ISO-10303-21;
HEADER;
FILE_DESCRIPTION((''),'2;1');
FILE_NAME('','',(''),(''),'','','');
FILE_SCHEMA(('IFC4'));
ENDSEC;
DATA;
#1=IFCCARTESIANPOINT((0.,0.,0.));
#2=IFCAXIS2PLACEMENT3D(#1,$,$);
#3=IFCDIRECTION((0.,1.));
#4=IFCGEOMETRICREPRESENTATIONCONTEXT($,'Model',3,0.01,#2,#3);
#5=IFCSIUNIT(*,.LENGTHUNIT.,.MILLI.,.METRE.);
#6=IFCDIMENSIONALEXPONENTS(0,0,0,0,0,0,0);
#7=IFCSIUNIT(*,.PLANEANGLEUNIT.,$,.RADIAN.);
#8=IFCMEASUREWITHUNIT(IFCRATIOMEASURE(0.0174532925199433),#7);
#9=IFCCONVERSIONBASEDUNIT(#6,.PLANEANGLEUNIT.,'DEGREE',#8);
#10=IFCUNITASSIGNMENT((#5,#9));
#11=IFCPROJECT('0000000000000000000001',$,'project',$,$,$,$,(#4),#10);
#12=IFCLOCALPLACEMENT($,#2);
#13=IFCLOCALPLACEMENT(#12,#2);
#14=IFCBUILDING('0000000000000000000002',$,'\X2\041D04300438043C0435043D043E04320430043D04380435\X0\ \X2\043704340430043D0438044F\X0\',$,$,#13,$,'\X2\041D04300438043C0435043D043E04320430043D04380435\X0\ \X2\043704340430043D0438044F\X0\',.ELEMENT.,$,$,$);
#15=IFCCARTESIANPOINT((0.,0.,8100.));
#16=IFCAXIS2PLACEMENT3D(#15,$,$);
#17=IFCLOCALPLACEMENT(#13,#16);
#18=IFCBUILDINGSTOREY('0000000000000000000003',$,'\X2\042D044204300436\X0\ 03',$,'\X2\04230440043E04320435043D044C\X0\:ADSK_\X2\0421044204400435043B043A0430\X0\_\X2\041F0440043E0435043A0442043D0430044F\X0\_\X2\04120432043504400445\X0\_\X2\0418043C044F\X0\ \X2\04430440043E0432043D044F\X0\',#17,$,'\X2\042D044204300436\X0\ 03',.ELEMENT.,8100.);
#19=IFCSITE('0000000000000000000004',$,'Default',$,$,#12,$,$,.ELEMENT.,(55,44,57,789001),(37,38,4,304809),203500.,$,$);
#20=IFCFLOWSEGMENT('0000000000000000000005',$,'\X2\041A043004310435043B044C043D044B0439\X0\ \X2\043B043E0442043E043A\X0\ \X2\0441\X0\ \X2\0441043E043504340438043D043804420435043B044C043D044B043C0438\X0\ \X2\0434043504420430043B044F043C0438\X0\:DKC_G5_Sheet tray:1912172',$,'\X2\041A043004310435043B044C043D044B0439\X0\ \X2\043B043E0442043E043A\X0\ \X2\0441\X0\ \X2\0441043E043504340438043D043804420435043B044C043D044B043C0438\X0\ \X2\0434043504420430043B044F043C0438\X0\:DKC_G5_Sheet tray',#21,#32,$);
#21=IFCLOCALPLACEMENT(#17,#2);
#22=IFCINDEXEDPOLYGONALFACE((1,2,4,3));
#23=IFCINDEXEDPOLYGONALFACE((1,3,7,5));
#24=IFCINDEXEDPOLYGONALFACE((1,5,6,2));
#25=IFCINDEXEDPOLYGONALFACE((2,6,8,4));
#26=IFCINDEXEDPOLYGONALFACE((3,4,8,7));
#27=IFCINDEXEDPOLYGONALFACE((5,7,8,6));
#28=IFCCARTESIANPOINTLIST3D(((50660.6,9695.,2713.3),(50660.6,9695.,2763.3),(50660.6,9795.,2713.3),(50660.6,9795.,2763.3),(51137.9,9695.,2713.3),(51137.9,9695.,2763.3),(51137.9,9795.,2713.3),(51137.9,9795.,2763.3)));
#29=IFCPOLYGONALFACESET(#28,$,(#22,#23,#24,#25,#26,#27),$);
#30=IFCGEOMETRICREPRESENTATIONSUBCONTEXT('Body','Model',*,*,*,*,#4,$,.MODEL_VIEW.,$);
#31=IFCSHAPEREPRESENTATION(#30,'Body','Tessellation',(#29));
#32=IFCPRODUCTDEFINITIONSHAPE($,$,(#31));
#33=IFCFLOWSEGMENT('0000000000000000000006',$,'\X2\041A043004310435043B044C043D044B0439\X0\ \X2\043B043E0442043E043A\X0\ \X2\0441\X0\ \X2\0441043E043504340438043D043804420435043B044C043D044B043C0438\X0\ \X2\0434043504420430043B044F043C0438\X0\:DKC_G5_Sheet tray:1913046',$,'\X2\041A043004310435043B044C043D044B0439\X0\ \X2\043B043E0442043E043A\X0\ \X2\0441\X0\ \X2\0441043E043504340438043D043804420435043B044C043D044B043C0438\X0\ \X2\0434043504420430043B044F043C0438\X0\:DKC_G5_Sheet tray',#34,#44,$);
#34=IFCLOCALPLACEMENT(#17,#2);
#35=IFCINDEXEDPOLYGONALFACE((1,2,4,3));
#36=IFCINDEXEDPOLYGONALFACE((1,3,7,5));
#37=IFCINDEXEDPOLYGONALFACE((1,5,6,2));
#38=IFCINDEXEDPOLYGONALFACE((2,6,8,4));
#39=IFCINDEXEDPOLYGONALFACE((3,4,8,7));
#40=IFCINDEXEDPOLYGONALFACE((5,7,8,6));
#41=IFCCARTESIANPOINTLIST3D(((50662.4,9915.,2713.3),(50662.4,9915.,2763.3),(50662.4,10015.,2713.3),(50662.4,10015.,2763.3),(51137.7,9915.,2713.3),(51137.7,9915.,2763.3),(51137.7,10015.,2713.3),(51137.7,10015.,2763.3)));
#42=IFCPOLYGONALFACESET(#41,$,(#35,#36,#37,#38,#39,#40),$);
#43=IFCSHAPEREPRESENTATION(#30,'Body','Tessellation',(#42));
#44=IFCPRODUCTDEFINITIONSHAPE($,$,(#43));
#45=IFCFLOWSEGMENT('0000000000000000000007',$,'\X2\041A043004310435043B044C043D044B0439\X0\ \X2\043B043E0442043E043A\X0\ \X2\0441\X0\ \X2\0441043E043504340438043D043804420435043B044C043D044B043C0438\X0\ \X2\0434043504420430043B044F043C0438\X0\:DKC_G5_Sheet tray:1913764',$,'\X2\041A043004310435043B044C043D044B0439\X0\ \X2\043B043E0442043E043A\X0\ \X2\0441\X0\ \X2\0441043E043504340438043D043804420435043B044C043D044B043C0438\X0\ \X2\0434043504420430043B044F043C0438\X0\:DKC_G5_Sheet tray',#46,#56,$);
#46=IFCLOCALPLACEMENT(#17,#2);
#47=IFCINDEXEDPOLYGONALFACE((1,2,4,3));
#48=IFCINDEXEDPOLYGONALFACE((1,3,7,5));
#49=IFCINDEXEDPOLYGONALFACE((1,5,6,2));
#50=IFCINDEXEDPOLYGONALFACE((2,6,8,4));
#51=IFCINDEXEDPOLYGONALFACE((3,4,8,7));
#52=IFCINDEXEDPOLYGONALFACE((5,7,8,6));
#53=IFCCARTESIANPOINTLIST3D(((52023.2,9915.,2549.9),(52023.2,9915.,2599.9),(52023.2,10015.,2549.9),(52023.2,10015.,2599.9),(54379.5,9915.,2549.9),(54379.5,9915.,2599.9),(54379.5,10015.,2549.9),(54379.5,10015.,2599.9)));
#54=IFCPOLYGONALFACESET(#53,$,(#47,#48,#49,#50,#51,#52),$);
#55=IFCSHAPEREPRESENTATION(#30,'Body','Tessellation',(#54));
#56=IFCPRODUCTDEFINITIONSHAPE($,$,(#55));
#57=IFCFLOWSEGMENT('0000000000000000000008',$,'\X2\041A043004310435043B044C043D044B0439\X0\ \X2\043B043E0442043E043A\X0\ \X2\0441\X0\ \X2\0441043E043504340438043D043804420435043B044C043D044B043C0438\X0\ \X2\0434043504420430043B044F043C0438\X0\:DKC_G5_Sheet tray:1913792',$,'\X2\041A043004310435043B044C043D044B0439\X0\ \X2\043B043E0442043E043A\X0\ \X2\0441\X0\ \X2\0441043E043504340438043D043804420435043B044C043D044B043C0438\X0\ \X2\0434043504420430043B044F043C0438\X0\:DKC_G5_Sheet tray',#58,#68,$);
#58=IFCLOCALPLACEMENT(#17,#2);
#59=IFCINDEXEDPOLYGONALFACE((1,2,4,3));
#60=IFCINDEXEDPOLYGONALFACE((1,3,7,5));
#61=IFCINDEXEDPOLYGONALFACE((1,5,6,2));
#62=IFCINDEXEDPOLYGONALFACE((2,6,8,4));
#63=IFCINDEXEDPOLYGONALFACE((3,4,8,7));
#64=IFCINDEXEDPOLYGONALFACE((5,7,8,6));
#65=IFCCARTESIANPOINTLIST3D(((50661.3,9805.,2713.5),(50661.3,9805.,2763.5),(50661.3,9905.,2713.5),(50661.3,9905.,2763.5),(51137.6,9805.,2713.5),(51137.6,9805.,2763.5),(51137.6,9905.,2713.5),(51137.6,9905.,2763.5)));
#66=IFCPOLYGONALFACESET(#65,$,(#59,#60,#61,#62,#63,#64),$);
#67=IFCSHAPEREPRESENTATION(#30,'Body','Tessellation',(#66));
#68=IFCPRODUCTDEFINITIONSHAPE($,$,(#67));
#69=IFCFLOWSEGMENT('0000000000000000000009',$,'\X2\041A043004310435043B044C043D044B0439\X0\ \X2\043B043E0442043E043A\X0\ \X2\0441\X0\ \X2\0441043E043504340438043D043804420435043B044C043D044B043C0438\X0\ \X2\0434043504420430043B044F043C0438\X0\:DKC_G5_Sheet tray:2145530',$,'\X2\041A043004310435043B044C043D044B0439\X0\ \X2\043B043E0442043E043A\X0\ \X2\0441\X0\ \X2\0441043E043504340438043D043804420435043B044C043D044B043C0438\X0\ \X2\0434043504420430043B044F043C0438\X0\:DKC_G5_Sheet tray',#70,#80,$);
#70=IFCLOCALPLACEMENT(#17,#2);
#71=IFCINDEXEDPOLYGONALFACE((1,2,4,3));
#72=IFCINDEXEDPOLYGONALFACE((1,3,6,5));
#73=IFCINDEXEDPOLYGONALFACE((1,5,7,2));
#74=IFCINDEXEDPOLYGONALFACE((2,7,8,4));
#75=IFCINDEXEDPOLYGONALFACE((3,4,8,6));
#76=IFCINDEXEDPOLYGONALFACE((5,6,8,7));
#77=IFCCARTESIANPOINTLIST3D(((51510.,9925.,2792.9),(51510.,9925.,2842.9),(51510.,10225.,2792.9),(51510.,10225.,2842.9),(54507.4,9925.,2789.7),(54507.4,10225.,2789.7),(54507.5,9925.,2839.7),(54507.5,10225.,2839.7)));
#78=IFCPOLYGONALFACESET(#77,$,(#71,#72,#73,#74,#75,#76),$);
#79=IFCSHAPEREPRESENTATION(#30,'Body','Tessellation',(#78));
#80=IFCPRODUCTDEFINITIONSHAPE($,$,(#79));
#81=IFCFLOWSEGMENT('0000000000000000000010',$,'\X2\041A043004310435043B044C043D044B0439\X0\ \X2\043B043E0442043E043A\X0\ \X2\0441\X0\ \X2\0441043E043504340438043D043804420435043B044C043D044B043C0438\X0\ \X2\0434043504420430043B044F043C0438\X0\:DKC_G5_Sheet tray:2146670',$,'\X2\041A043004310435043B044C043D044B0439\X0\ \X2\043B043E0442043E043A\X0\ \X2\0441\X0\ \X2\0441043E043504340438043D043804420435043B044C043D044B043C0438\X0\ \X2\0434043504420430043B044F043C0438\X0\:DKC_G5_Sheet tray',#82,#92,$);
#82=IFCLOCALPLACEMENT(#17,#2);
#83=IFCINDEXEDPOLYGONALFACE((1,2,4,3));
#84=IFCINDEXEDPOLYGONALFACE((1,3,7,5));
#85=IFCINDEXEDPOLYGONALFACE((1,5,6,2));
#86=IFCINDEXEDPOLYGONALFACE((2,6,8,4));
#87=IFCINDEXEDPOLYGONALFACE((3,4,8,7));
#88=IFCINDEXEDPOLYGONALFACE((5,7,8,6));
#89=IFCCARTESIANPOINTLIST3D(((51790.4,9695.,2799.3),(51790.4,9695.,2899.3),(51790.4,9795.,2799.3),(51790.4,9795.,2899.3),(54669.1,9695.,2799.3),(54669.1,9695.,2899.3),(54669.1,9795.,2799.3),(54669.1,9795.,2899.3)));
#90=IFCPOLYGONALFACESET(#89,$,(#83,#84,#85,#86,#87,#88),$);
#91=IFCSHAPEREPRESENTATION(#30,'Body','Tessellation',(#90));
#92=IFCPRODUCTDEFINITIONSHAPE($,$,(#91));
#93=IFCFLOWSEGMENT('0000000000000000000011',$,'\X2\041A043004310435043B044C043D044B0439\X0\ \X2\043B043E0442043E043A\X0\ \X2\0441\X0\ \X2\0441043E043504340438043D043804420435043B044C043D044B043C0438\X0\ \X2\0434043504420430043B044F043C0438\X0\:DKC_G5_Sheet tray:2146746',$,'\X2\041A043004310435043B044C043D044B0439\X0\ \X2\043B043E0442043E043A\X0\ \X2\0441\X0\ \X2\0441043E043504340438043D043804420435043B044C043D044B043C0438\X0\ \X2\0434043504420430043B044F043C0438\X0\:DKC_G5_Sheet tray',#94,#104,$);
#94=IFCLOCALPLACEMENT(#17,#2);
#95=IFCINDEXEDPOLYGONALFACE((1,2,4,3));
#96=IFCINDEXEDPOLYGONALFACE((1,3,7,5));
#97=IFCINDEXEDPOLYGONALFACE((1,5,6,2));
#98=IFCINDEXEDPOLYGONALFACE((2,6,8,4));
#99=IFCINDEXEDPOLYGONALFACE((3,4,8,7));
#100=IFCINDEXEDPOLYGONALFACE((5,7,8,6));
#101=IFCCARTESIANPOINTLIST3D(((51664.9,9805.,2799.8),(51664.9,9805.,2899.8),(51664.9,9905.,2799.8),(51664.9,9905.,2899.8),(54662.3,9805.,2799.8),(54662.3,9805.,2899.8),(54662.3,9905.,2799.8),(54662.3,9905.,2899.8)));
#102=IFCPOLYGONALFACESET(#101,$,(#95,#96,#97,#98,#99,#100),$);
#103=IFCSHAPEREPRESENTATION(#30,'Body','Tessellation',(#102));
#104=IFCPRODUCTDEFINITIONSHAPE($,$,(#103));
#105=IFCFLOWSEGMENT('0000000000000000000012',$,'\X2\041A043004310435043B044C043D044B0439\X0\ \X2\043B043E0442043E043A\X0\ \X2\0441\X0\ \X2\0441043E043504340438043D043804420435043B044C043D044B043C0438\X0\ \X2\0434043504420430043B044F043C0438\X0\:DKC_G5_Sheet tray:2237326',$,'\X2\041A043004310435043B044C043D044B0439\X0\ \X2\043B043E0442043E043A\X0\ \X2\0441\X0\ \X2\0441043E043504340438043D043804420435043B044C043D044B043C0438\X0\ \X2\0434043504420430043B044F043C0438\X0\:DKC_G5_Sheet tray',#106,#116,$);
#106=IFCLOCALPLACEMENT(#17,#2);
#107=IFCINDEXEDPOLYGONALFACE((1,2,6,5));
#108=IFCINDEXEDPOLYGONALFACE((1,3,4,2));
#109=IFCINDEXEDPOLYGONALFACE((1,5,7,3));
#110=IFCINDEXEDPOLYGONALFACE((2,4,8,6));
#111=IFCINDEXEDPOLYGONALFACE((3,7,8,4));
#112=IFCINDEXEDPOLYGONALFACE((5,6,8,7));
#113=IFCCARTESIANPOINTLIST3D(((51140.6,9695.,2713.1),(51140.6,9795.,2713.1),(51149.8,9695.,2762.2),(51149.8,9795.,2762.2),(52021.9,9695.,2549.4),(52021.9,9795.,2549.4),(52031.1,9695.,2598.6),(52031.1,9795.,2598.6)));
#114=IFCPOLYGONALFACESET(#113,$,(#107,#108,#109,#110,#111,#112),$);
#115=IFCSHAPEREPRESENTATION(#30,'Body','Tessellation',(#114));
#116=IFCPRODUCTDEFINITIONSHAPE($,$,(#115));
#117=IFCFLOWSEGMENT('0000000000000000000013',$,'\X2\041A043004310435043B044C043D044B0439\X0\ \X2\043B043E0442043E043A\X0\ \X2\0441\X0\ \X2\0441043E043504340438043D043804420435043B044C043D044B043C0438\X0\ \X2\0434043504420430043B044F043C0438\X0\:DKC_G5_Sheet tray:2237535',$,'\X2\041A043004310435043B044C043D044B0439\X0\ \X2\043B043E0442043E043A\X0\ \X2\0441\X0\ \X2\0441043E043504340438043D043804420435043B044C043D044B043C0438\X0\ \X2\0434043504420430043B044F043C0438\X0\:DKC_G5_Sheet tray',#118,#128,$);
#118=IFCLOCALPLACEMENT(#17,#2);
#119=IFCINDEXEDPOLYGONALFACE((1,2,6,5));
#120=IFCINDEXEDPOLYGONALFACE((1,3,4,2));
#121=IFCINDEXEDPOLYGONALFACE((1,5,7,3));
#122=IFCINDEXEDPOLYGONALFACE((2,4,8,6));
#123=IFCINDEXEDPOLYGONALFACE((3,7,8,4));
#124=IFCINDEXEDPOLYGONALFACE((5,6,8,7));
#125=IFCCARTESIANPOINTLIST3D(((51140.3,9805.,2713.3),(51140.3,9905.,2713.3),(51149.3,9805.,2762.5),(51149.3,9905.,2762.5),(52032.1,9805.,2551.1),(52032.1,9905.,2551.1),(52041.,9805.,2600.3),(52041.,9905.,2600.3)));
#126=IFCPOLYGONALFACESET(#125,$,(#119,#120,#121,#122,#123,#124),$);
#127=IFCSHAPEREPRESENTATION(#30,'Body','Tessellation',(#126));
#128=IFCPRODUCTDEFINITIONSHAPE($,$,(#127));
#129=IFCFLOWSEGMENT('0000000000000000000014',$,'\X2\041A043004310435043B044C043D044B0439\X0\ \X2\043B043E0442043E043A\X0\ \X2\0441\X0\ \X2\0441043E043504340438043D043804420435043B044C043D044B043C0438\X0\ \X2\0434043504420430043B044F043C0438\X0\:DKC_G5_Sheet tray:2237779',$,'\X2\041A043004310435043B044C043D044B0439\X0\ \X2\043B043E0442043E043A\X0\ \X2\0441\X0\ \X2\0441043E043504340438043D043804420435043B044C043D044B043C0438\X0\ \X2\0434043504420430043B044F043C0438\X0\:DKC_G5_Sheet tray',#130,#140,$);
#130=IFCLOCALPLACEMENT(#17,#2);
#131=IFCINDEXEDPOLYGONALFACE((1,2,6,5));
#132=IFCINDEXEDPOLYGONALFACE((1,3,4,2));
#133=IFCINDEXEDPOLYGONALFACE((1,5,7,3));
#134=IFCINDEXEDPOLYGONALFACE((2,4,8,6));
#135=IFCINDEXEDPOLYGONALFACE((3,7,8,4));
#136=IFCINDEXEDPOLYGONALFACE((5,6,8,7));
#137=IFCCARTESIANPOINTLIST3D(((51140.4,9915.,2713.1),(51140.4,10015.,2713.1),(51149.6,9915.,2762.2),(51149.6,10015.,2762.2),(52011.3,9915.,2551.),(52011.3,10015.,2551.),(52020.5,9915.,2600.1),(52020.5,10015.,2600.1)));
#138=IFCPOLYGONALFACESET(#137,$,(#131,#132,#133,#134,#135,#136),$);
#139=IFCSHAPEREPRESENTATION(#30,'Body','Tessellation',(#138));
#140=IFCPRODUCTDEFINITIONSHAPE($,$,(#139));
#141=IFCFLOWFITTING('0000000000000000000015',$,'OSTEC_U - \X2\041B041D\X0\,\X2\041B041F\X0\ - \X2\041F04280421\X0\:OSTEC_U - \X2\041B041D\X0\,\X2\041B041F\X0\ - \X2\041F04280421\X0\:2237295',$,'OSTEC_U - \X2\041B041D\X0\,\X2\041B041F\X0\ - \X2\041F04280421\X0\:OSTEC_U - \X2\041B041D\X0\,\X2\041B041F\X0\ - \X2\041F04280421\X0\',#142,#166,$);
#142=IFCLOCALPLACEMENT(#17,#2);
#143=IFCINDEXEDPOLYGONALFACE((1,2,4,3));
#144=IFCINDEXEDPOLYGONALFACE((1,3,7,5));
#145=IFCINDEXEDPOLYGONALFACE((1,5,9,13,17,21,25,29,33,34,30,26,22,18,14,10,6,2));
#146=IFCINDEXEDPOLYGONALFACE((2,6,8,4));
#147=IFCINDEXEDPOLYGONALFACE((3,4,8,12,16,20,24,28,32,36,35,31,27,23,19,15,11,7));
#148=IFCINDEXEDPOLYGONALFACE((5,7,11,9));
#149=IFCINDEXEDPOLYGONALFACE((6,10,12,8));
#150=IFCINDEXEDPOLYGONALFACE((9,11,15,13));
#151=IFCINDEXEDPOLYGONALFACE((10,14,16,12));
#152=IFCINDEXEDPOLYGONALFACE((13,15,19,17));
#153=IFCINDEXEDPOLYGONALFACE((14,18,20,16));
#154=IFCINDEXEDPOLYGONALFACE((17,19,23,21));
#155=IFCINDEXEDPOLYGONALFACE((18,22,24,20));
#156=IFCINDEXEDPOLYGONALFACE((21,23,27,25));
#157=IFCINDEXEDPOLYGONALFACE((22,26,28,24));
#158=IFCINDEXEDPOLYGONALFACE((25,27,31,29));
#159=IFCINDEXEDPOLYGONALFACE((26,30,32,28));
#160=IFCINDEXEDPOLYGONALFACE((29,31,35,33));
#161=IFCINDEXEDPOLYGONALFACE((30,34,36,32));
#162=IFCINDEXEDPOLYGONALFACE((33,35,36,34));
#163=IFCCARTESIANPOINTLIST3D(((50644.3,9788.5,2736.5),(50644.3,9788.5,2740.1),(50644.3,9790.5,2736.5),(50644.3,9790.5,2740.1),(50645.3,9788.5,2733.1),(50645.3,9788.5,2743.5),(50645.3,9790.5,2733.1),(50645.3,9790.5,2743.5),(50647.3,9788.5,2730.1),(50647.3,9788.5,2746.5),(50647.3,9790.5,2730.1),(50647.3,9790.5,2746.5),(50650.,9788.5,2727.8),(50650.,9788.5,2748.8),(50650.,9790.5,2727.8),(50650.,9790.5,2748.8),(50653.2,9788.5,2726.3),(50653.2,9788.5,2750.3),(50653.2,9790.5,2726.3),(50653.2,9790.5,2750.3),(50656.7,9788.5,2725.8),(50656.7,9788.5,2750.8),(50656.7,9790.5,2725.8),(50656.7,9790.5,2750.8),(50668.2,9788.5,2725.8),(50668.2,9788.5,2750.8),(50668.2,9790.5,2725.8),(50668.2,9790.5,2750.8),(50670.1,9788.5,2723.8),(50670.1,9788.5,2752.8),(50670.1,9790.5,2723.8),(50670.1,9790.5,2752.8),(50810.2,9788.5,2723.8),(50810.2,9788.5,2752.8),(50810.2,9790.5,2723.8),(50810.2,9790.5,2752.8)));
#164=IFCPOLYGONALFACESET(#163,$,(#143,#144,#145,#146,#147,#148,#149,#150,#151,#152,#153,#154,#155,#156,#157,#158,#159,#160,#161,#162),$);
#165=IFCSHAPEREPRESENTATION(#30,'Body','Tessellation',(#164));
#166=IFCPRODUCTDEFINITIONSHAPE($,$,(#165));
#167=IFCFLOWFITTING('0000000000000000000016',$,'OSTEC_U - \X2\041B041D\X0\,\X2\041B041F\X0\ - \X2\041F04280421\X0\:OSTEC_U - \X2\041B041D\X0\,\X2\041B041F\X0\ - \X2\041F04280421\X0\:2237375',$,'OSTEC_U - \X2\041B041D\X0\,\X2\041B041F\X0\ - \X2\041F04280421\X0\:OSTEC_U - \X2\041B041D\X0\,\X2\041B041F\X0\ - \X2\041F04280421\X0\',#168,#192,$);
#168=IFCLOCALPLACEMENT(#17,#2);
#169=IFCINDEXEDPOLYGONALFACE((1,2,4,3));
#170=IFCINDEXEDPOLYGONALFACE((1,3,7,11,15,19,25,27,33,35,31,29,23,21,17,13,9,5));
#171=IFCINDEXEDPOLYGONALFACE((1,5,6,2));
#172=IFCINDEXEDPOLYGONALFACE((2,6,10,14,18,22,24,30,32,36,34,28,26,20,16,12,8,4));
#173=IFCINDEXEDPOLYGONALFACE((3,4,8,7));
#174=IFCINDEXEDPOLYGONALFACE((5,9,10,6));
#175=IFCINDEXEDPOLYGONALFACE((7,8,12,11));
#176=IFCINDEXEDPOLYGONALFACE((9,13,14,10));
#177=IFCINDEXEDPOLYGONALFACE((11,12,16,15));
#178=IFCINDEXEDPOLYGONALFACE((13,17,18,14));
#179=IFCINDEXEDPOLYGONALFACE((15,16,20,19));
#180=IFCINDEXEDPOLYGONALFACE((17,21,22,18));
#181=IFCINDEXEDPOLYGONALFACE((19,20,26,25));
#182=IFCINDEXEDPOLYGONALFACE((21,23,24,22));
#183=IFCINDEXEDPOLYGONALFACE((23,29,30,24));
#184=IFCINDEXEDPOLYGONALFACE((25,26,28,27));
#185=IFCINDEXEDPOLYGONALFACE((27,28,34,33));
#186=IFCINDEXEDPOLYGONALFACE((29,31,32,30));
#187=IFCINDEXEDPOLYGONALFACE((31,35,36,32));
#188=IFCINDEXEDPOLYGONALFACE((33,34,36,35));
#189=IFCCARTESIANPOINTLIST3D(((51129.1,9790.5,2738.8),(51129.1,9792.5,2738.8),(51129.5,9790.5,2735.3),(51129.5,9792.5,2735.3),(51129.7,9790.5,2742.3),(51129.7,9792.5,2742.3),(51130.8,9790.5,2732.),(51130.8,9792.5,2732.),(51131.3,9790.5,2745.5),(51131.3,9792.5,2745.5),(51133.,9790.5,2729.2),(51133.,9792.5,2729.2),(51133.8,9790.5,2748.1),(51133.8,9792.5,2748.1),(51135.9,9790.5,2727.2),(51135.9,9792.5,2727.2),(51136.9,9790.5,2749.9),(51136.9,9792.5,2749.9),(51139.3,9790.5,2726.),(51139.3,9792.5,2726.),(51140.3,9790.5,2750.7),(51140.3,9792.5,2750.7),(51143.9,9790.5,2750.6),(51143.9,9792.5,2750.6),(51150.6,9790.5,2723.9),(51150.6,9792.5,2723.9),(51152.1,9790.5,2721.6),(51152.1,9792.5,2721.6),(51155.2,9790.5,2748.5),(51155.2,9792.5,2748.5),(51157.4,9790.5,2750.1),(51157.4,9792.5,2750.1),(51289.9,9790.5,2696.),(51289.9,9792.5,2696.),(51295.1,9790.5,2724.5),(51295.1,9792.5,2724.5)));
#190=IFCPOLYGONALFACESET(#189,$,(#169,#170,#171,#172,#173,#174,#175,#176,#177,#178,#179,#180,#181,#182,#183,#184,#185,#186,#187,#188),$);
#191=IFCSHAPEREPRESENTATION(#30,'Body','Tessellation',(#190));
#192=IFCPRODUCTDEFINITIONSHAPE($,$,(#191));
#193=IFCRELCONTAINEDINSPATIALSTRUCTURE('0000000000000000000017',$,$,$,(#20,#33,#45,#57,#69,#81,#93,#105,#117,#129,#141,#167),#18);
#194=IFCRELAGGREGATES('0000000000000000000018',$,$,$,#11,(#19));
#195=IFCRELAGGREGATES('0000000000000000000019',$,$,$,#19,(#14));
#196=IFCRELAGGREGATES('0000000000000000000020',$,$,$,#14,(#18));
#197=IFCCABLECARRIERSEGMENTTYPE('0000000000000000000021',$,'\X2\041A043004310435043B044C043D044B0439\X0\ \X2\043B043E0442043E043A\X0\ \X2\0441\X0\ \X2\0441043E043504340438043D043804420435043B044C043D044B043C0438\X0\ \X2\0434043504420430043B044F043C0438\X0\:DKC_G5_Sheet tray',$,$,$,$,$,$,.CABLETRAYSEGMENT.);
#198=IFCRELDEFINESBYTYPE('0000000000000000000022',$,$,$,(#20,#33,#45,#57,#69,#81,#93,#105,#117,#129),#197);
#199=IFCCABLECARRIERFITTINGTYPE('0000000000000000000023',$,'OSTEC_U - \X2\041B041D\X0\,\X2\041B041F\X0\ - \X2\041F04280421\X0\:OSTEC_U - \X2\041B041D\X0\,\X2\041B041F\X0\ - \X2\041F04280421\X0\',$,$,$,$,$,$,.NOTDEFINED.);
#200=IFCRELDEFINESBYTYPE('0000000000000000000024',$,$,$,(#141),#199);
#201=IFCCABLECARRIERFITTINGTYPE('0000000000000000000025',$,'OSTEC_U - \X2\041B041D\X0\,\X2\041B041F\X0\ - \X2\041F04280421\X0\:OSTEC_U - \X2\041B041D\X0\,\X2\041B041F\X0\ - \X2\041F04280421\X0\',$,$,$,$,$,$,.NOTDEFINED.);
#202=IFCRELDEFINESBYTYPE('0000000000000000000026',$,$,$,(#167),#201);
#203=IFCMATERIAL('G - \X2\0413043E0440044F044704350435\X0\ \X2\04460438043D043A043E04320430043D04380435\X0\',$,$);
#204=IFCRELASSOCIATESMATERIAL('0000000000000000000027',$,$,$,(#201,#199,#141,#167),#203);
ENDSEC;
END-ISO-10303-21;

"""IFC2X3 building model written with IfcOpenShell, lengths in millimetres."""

from ifc_helpers import new_model, entity, si_unit, converted_unit, direction, frame, frame_2d, origin, origin_2d_with_axis, place, context, subcontext, project, spatial, polyline, circle_curve, parameter, trimmed, segment, composite_curve, rectangle, outline, extrude, source, transform, mapped, material, type_object, type_shapes, element, save


model = new_model("IFC2X3")

# Units and contexts
model_context = context("Model", 3, precision=0.01, world=origin(), true_north=direction((0.0, 1.0)))
body_context = subcontext(model_context, "Body", "Model", "MODEL_VIEW")
ifc_project = project(units=[si_unit("LENGTHUNIT", "METRE", prefix="MILLI"), converted_unit("PLANEANGLEUNIT", "DEGREE", entity("IfcRatioMeasure", 0.0174532925199433), si_unit("PLANEANGLEUNIT", "RADIAN"), dimensions=[0, 0, 0, 0, 0, 0, 0])], contexts=[model_context])

# Site, building, storey
site_placement = place(None, origin())
site = spatial("IfcSite", under=ifc_project, at=site_placement, Name="Default", CompositionType="ELEMENT", RefLatitude=(55, 44, 57, 789001), RefLongitude=(37, 38, 4, 304809), RefElevation=203500.0)
building_placement = place(site_placement, origin())
building = spatial("IfcBuilding", under=site, at=building_placement, Name="Наименование здания", LongName="Наименование здания", CompositionType="ELEMENT")
storey_placement = place(building_placement, frame((0.0, 0.0, 8100.0)))
storey = spatial("IfcBuildingStorey", under=building, at=storey_placement, Name="Этаж 03", ObjectType="Уровень:ADSK_Стрелка_Проектная_Вверх_Имя уровня", LongName="Этаж 03", CompositionType="ELEMENT", Elevation=8100.0)

# Flow segments
cable_carrier_segment_type = type_object("IfcCableCarrierSegmentType", Name="Кабельный лоток с соединительными деталями:DKC_G5_Sheet tray", PredefinedType="CABLETRAYSEGMENT")
flow_segment_1_placement = place(storey_placement, frame((50660.6, 9695.0, 2713.3)))
element("IfcFlowSegment", 1, at=flow_segment_1_placement, inside=storey, type_object=cable_carrier_segment_type, Name="Кабельный лоток с соединительными деталями:DKC_G5_Sheet tray:1912172", ObjectType="Кабельный лоток с соединительными деталями:DKC_G5_Sheet tray", context=body_context, shape_type="SweptSolid", body=[
    extrude(rectangle(XDim=477.3, YDim=100.0, at=origin_2d_with_axis()), frame((238.6, 50.0, 0.0)), (0.0, 0.0, 1.0), 50.0),
])
flow_segment_2_placement = place(storey_placement, frame((50662.4, 9915.0, 2713.3)))
element("IfcFlowSegment", 2, at=flow_segment_2_placement, inside=storey, type_object=cable_carrier_segment_type, Name="Кабельный лоток с соединительными деталями:DKC_G5_Sheet tray:1913046", ObjectType="Кабельный лоток с соединительными деталями:DKC_G5_Sheet tray", context=body_context, shape_type="SweptSolid", body=[
    extrude(rectangle(XDim=475.3, YDim=100.0, at=origin_2d_with_axis()), frame((237.7, 50.0, 0.0)), (0.0, 0.0, 1.0), 50.0),
])
flow_segment_3_placement = place(storey_placement, frame((52023.2, 9915.0, 2549.9)))
element("IfcFlowSegment", 3, at=flow_segment_3_placement, inside=storey, type_object=cable_carrier_segment_type, Name="Кабельный лоток с соединительными деталями:DKC_G5_Sheet tray:1913764", ObjectType="Кабельный лоток с соединительными деталями:DKC_G5_Sheet tray", context=body_context, shape_type="SweptSolid", body=[
    extrude(rectangle(XDim=2356.3, YDim=100.0, at=origin_2d_with_axis()), frame((1178.2, 50.0, 0.0), z_axis=(0.0, 0.0, 1.0), x_axis=(-1.0, 0.0, 0.0)), (0.0, 0.0, 1.0), 50.0),
])
flow_segment_4_placement = place(storey_placement, frame((50661.3, 9805.0, 2713.5)))
element("IfcFlowSegment", 4, at=flow_segment_4_placement, inside=storey, type_object=cable_carrier_segment_type, Name="Кабельный лоток с соединительными деталями:DKC_G5_Sheet tray:1913792", ObjectType="Кабельный лоток с соединительными деталями:DKC_G5_Sheet tray", context=body_context, shape_type="SweptSolid", body=[
    extrude(rectangle(XDim=476.4, YDim=100.0, at=origin_2d_with_axis()), frame((238.2, 50.0, 0.0), z_axis=(0.0, 0.0, 1.0), x_axis=(-1.0, 0.0, 0.0)), (0.0, 0.0, 1.0), 50.0),
])
flow_segment_5_placement = place(storey_placement, frame((51509.9, 9925.0, 2789.7)))
element("IfcFlowSegment", 5, at=flow_segment_5_placement, inside=storey, type_object=cable_carrier_segment_type, Name="Кабельный лоток с соединительными деталями:DKC_G5_Sheet tray:2145530", ObjectType="Кабельный лоток с соединительными деталями:DKC_G5_Sheet tray", context=body_context, shape_type="SweptSolid", body=[
    extrude(rectangle(XDim=2997.5, YDim=300.0, at=origin_2d_with_axis()), frame((1498.7, 150.0, 1.6), z_axis=(0.00105, 0.0, 0.999999), x_axis=(0.999999, 0.0, -0.00105)), (0.0, 0.0, 1.0), 50.0),
])
flow_segment_6_placement = place(storey_placement, frame((51790.4, 9695.0, 2799.3)))
element("IfcFlowSegment", 6, at=flow_segment_6_placement, inside=storey, type_object=cable_carrier_segment_type, Name="Кабельный лоток с соединительными деталями:DKC_G5_Sheet tray:2146670", ObjectType="Кабельный лоток с соединительными деталями:DKC_G5_Sheet tray", context=body_context, shape_type="SweptSolid", body=[
    extrude(rectangle(XDim=2878.7, YDim=100.0, at=origin_2d_with_axis()), frame((1439.4, 50.0, 0.0)), (0.0, 0.0, 1.0), 100.0),
])
flow_segment_7_placement = place(storey_placement, frame((51664.9, 9805.0, 2799.8)))
element("IfcFlowSegment", 7, at=flow_segment_7_placement, inside=storey, type_object=cable_carrier_segment_type, Name="Кабельный лоток с соединительными деталями:DKC_G5_Sheet tray:2146746", ObjectType="Кабельный лоток с соединительными деталями:DKC_G5_Sheet tray", context=body_context, shape_type="SweptSolid", body=[
    extrude(rectangle(XDim=2997.5, YDim=100.0, at=origin_2d_with_axis()), frame((1498.7, 50.0, 0.0)), (0.0, 0.0, 1.0), 100.0),
])
flow_segment_8_placement = place(storey_placement, frame((51140.6, 9695.0, 2549.4)))
element("IfcFlowSegment", 8, at=flow_segment_8_placement, inside=storey, type_object=cable_carrier_segment_type, Name="Кабельный лоток с соединительными деталями:DKC_G5_Sheet tray:2237326", ObjectType="Кабельный лоток с соединительными деталями:DKC_G5_Sheet tray", context=body_context, shape_type="SweptSolid", body=[
    extrude(rectangle(XDim=50.0, YDim=100.0, at=origin_2d_with_axis()), frame((4.6, 50.0, 188.2), z_axis=(0.983195, 0.0, -0.182559), x_axis=(0.182559, 0.0, 0.983195)), (0.0, 0.0, 1.0), 896.4),
])
flow_segment_9_placement = place(storey_placement, frame((51140.3, 9805.0, 2551.1)))
element("IfcFlowSegment", 9, at=flow_segment_9_placement, inside=storey, type_object=cable_carrier_segment_type, Name="Кабельный лоток с соединительными деталями:DKC_G5_Sheet tray:2237535", ObjectType="Кабельный лоток с соединительными деталями:DKC_G5_Sheet tray", context=body_context, shape_type="SweptSolid", body=[
    extrude(rectangle(XDim=50.0, YDim=100.0, at=frame_2d((0.0, 0.0), x_axis=(0.0, 1.0))), frame((4.5, 50.0, 186.8), z_axis=(0.983855, 0.0, -0.178966), x_axis=(0.0, 1.0, 0.0)), (0.0, 0.0, 1.0), 906.4),
])
flow_segment_10_placement = place(storey_placement, frame((51140.4, 9915.0, 2551.0)))
element("IfcFlowSegment", 10, at=flow_segment_10_placement, inside=storey, type_object=cable_carrier_segment_type, Name="Кабельный лоток с соединительными деталями:DKC_G5_Sheet tray:2237779", ObjectType="Кабельный лоток с соединительными деталями:DKC_G5_Sheet tray", context=body_context, shape_type="SweptSolid", body=[
    extrude(rectangle(XDim=50.0, YDim=100.0, at=frame_2d((0.0, 0.0), x_axis=(0.0, 1.0))), frame((4.6, 50.0, 186.7), z_axis=(0.983116, 0.0, -0.182982), x_axis=(0.0, 1.0, 0.0)), (0.0, 0.0, 1.0), 885.8),
])

# Flow fittings
ifc_material = material(Name="G - Горячее цинкование")
cable_carrier_fitting_type_1 = type_object("IfcCableCarrierFittingType", Name="OSTEC_U - ЛН,ЛП - ПШС:OSTEC_U - ЛН,ЛП - ПШС", PredefinedType="NOTDEFINED", material=ifc_material)
shared_shape_1 = source(origin(), body_context, "Body", "SweptSolid", [
    extrude(outline(composite_curve([segment(trimmed(circle_curve(frame_2d((-44.6, 0.0), x_axis=(1.0, 0.0)), 12.5), [parameter(90.0)], [parameter(270.0)], True, "PARAMETER"), True, "CONTINUOUS"), segment(polyline([(-44.6, -12.5), (-33.1, -12.5)]), True, "CONTINUOUS"), segment(polyline([(-33.1, -12.5), (-31.2, -14.5)]), True, "CONTINUOUS"), segment(polyline([(-31.2, -14.5), (108.9, -14.5)]), True, "CONTINUOUS"), segment(polyline([(108.9, -14.5), (108.9, 14.5)]), True, "CONTINUOUS"), segment(polyline([(108.9, 14.5), (-31.2, 14.5)]), True, "CONTINUOUS"), segment(polyline([(-31.2, 14.5), (-33.1, 12.5)]), True, "CONTINUOUS"), segment(polyline([(-33.1, 12.5), (-44.6, 12.5)]), True, "CONTINUOUS")], self_intersect=False)), frame((44.6, 0.0, 0.0), z_axis=(0.0, 0.0, -1.0), x_axis=(1.0, 0.0, 0.0)), (0.0, 0.0, -1.0), 2.0),
])
type_shapes(cable_carrier_fitting_type_1, [shared_shape_1])
cable_carrier_fitting_type_2 = type_object("IfcCableCarrierFittingType", Name="OSTEC_U - ЛН,ЛП - ПШС:OSTEC_U - ЛН,ЛП - ПШС", PredefinedType="NOTDEFINED", material=ifc_material)
type_shapes(cable_carrier_fitting_type_2, [shared_shape_1])
flow_fitting_1_placement = place(storey_placement, frame((50656.7, 9788.5, 2738.3), z_axis=(0.000003, 1.0, -0.000015), x_axis=(1.0, -0.000003, 0.0)))
element("IfcFlowFitting", 11, at=flow_fitting_1_placement, inside=storey, type_object=cable_carrier_fitting_type_2, material=ifc_material, Name="OSTEC_U - ЛН,ЛП - ПШС:OSTEC_U - ЛН,ЛП - ПШС:2237295", ObjectType="OSTEC_U - ЛН,ЛП - ПШС:OSTEC_U - ЛН,ЛП - ПШС", context=body_context, shape_type="MappedRepresentation", body=[
    mapped(shared_shape_1, transform((0.0, 0.0, 0.0), scale=1.0)),
])
flow_fitting_2_placement = place(storey_placement, frame((51141.6, 9790.5, 2738.3), z_axis=(0.000003, 1.0, 0.000016), x_axis=(0.983195, 0.0, -0.182559)))
element("IfcFlowFitting", 12, at=flow_fitting_2_placement, inside=storey, type_object=cable_carrier_fitting_type_1, material=ifc_material, Name="OSTEC_U - ЛН,ЛП - ПШС:OSTEC_U - ЛН,ЛП - ПШС:2237375", ObjectType="OSTEC_U - ЛН,ЛП - ПШС:OSTEC_U - ЛН,ЛП - ПШС", context=body_context, shape_type="MappedRepresentation", body=[
    mapped(shared_shape_1, transform((0.0, 0.0, 0.0), scale=1.0)),
])

save(model, "model.ifc")
